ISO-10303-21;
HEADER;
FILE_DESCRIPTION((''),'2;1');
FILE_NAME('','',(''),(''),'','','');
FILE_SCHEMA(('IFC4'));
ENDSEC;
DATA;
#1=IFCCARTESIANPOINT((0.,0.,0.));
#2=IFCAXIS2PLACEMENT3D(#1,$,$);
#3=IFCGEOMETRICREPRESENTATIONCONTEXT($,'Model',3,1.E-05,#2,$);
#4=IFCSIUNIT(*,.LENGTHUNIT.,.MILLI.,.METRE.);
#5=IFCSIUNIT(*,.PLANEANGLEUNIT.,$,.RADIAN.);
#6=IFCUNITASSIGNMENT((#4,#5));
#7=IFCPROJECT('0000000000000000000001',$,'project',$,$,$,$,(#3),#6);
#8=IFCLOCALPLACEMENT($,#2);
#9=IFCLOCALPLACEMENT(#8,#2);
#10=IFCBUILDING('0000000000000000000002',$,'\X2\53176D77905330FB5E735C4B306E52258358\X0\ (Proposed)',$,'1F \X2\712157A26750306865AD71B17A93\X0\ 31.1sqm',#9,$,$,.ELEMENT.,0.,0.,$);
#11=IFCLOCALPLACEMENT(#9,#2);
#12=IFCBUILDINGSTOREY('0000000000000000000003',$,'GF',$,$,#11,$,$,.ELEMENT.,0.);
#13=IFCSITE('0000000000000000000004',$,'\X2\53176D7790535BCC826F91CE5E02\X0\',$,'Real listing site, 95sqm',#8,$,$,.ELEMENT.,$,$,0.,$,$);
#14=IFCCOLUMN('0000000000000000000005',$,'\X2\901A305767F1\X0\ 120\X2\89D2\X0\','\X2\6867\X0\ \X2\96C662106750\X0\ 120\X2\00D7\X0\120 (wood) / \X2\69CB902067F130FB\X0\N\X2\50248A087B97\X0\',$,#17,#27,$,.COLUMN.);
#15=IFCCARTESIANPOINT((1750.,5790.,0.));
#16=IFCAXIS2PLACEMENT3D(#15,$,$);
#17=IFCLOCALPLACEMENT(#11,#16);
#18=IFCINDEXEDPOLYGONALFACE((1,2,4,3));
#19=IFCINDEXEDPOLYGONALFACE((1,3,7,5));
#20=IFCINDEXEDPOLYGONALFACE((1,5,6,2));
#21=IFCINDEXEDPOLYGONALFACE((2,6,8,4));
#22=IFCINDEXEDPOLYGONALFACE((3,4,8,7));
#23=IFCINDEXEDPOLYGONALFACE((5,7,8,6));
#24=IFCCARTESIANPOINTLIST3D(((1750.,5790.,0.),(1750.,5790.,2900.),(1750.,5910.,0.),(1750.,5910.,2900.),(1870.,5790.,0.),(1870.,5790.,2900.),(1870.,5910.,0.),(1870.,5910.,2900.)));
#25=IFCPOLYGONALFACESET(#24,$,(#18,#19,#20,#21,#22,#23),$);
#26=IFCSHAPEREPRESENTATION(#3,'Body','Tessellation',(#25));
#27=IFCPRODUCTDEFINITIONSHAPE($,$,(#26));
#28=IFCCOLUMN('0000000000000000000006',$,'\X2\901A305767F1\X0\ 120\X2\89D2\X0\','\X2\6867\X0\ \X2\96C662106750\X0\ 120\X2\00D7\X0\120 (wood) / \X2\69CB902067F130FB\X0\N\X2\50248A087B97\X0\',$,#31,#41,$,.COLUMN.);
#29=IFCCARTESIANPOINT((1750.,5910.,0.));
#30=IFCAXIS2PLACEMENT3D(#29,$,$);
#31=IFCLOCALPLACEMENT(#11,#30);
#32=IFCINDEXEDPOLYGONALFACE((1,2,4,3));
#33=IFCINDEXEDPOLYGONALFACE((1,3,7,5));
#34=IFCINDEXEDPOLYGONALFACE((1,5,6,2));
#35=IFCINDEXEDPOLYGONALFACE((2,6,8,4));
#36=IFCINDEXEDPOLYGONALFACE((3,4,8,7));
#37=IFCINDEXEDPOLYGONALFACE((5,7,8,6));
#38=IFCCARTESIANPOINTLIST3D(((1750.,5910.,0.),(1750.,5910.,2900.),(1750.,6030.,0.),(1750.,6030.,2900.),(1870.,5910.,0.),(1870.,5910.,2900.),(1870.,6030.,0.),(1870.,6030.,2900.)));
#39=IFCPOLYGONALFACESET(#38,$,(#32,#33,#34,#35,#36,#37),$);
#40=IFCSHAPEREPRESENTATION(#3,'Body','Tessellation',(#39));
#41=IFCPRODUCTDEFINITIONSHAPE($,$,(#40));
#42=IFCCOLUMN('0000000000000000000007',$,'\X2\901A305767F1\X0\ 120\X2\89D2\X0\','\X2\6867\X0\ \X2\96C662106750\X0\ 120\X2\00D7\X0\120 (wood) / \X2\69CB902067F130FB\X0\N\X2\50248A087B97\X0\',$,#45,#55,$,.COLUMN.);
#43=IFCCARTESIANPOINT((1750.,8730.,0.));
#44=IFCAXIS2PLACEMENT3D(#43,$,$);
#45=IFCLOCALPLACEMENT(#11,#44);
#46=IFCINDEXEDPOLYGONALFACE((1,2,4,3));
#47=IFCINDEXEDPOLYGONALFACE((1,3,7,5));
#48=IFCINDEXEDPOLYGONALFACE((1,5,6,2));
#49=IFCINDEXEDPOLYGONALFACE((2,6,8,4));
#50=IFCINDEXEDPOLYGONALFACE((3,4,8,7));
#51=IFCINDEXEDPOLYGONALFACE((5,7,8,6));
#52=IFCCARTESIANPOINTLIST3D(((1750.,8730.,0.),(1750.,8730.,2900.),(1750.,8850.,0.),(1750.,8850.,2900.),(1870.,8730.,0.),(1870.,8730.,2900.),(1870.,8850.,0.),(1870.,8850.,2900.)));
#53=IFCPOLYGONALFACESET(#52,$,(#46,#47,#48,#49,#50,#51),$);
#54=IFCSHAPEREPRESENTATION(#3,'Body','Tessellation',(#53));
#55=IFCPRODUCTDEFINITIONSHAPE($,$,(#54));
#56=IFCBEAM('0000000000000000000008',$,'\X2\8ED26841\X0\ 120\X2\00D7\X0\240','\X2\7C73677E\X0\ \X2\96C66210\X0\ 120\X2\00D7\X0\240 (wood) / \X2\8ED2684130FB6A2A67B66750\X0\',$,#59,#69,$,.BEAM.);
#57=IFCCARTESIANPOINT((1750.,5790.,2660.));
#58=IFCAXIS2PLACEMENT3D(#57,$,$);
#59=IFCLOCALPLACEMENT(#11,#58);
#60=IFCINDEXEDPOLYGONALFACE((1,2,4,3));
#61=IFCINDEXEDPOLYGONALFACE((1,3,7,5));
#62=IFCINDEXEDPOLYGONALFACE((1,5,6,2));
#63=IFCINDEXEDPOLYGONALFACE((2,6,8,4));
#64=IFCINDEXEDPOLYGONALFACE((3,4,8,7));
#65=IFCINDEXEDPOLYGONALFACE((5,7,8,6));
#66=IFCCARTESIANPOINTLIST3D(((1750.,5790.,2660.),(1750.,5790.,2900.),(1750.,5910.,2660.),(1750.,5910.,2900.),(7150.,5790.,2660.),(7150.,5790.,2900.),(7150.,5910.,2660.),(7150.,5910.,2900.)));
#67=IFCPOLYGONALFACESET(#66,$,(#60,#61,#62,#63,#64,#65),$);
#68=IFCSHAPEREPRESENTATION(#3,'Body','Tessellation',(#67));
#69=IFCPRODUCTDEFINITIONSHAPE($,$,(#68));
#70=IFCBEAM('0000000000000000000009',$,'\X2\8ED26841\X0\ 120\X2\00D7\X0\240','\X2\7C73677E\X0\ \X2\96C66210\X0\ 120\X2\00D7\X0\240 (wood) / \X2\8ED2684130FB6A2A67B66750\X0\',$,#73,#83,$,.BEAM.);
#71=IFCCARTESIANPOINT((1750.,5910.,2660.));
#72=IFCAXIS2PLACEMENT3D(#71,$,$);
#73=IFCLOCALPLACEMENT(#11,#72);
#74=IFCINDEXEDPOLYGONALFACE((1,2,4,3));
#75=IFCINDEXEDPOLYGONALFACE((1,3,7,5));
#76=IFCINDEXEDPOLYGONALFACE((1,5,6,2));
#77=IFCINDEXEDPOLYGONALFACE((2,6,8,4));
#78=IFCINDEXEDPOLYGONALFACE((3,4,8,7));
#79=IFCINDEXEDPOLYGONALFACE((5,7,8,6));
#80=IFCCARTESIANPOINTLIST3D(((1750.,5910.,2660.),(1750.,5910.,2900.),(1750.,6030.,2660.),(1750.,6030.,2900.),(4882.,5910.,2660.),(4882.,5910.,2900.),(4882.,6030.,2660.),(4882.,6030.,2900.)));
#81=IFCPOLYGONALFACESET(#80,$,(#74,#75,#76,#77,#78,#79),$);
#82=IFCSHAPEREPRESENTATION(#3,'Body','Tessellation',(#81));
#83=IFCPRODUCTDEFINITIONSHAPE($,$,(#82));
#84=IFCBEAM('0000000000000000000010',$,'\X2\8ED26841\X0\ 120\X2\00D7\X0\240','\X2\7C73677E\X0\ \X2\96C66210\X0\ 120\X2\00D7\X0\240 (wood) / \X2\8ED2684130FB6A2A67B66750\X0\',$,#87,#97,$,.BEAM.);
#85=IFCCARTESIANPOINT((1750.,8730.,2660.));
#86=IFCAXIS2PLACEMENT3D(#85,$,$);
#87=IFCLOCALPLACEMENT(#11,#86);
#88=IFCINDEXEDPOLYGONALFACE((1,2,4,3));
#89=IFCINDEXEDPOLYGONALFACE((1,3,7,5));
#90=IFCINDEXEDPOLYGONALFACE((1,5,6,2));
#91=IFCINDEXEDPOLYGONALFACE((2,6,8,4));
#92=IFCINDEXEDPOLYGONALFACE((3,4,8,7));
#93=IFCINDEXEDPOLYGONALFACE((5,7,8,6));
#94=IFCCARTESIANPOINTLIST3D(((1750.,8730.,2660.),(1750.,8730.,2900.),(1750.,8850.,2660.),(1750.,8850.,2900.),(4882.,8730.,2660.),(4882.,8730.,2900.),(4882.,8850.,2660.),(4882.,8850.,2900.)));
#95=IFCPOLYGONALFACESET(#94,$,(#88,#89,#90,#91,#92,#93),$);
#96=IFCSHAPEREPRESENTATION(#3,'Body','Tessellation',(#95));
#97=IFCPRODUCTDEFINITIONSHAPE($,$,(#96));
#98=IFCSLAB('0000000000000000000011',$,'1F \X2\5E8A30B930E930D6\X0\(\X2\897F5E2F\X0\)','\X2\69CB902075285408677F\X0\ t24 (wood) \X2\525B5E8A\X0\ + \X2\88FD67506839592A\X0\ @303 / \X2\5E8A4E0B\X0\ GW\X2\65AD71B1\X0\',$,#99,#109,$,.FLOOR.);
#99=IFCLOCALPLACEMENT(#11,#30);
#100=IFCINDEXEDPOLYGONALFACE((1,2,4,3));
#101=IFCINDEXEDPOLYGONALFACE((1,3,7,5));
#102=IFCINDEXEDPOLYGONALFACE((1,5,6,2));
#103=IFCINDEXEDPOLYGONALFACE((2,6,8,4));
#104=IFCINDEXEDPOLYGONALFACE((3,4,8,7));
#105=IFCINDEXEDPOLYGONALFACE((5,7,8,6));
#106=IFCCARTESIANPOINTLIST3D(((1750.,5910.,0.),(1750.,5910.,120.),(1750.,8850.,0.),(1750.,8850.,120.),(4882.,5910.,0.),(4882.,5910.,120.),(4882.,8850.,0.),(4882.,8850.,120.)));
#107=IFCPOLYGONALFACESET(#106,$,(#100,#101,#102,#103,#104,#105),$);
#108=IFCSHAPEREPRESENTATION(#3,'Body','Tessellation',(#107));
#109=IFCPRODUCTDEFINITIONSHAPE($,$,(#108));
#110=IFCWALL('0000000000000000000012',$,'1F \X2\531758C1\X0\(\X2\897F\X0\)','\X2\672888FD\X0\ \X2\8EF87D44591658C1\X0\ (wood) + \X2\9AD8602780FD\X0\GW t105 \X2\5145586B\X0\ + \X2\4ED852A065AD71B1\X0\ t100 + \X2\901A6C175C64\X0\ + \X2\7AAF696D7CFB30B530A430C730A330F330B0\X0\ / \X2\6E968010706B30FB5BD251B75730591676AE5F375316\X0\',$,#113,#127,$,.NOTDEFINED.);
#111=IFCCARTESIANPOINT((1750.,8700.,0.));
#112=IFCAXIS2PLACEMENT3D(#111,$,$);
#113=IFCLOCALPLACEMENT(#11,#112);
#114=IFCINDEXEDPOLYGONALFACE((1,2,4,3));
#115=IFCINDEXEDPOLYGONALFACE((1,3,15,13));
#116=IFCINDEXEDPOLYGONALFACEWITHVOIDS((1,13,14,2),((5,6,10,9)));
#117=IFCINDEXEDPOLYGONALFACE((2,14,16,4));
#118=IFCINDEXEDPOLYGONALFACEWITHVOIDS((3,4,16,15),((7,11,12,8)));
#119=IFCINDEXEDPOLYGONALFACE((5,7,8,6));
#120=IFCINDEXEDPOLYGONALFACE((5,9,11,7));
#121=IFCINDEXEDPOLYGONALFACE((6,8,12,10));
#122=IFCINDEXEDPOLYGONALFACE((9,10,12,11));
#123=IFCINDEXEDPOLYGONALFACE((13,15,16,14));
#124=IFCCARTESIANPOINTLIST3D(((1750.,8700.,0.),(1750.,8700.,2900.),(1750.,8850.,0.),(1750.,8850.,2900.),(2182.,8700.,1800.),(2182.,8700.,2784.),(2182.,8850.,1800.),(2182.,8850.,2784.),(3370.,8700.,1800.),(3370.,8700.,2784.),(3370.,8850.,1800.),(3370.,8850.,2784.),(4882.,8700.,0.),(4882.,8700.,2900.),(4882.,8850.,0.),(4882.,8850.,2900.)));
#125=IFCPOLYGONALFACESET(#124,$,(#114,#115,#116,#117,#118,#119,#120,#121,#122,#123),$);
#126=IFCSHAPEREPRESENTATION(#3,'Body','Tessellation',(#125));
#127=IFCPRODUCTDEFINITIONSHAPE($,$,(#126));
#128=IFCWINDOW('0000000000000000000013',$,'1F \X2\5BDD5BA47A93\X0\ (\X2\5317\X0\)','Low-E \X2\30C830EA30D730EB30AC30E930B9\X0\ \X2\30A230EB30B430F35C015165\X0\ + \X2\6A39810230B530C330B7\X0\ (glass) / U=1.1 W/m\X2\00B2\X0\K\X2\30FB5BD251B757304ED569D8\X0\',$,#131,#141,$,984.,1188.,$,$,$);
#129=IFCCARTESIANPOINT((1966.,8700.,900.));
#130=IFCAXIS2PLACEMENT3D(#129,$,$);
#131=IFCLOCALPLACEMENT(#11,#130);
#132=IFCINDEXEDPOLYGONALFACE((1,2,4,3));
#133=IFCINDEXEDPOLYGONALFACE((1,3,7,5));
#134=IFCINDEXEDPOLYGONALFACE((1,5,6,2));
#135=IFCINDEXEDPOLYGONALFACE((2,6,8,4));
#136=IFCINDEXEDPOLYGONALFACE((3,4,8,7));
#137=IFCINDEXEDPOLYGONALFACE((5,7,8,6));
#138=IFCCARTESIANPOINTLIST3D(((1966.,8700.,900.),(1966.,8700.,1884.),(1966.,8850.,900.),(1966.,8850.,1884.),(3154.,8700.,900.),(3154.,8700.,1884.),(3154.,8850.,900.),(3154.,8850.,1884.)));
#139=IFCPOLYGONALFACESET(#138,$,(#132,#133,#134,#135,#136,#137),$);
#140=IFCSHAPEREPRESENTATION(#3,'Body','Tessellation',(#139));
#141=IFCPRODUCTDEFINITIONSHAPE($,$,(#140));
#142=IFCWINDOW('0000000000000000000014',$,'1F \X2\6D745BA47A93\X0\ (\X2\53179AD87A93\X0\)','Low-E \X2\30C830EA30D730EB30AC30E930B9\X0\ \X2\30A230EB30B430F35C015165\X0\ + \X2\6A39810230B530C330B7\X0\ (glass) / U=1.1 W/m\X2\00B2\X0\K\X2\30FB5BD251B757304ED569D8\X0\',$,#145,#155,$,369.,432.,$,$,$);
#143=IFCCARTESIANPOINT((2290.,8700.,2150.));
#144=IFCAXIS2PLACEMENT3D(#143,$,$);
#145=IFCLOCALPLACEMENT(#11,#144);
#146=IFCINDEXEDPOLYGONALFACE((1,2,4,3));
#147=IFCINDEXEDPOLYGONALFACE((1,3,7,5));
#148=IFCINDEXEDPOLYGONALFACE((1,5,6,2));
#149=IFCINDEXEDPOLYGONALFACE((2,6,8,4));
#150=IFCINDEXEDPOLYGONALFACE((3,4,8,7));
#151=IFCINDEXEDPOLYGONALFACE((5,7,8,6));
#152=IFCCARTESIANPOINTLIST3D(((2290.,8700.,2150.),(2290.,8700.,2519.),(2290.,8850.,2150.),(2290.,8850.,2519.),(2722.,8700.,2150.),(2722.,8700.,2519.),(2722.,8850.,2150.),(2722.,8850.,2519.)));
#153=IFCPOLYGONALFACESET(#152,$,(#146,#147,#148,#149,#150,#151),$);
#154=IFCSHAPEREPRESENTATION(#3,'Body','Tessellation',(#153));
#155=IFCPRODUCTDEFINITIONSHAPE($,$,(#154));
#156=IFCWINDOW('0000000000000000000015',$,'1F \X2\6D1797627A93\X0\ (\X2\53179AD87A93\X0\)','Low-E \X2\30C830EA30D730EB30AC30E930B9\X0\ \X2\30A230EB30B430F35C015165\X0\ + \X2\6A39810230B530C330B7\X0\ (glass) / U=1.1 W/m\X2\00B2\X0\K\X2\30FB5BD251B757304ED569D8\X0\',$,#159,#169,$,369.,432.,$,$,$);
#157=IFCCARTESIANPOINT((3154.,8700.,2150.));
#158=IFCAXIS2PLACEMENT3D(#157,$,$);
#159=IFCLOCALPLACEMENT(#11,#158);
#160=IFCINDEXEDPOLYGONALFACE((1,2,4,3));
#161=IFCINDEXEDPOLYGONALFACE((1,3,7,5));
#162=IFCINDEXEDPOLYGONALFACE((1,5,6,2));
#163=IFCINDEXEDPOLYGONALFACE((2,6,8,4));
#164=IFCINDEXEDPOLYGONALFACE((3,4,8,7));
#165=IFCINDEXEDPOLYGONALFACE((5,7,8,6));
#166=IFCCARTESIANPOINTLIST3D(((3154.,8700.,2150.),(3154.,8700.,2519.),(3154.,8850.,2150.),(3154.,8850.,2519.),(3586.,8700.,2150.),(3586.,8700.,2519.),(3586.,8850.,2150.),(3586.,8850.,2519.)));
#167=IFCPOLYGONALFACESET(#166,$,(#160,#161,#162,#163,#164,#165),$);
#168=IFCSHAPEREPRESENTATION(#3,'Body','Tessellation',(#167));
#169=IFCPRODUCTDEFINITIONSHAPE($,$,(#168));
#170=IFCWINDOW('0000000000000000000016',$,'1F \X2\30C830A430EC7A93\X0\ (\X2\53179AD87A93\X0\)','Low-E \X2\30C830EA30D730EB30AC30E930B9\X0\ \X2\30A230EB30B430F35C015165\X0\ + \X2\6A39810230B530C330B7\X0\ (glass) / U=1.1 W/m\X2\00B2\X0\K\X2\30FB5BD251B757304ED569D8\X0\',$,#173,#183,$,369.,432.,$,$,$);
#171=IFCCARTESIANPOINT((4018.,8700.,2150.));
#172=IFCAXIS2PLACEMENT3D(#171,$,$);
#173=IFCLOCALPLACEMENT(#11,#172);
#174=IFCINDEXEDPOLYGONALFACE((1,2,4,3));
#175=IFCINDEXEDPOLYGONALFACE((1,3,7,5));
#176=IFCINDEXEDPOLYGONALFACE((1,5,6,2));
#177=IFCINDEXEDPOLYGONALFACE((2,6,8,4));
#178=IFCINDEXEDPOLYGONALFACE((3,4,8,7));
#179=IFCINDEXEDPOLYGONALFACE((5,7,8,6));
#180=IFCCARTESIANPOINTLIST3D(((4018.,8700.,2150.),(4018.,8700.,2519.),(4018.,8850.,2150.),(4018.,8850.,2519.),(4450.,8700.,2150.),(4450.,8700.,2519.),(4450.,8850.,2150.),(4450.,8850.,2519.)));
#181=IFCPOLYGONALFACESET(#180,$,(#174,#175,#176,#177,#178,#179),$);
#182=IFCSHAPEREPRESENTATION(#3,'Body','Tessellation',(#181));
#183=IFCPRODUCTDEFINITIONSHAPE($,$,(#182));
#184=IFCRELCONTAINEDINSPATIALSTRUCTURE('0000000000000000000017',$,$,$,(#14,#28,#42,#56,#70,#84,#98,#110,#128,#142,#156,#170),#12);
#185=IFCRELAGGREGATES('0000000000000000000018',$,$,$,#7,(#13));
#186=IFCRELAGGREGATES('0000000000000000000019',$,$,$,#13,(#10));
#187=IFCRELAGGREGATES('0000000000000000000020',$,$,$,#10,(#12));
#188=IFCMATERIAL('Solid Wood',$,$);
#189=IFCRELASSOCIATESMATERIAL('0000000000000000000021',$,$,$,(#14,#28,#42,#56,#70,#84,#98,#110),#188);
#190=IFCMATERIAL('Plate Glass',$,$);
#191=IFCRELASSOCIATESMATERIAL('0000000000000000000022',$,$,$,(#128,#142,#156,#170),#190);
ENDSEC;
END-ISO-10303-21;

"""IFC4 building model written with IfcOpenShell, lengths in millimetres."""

from ifc_helpers import new_model, si_unit, frame, frame_2d, origin, place, context, project, spatial, rectangle, extrude, material, element, fill, save


model = new_model("IFC4")

# Units and contexts
model_context = context("Model", 3, precision=1e-05, world=origin())
ifc_project = project(units=[si_unit("LENGTHUNIT", "METRE", prefix="MILLI"), si_unit("PLANEANGLEUNIT", "RADIAN")], contexts=[model_context])

# Site, building, storey
site_placement = place(None, origin())
site = spatial("IfcSite", under=ifc_project, at=site_placement, Name="北海道富良野市", ObjectType="Real listing site, 95sqm", CompositionType="ELEMENT", RefElevation=0.0)
building_placement = place(site_placement, origin())
building = spatial("IfcBuilding", under=site, at=building_placement, Name="北海道・平屋の別荘 (Proposed)", ObjectType="1F 無垢材と断熱窓 31.1sqm", CompositionType="ELEMENT", ElevationOfRefHeight=0.0, ElevationOfTerrain=0.0)
storey_placement = place(building_placement, origin())
storey = spatial("IfcBuildingStorey", under=building, at=storey_placement, Name="GF", CompositionType="ELEMENT", Elevation=0.0)

# Columns
ifc_material_1 = material(Name="Solid Wood")
column_1_placement = place(storey_placement, frame((1750.0, 5790.0, 0.0)))
element("IfcColumn", 1, at=column_1_placement, inside=storey, material=ifc_material_1, Name="通し柱 120角", Description="桧 集成材 120×120 (wood) / 構造柱・N値計算", PredefinedType="COLUMN", context=model_context, shape_type="SweptSolid", body=[
    extrude(rectangle(XDim=120.0, YDim=120.0, at=frame_2d((60.0, 60.0))), frame((1750.0, 5790.0, 0.0)), (0.0, 0.0, 1.0), 2900.0),
])
column_2_placement = place(storey_placement, frame((1750.0, 5910.0, 0.0)))
element("IfcColumn", 2, at=column_2_placement, inside=storey, material=ifc_material_1, Name="通し柱 120角", Description="桧 集成材 120×120 (wood) / 構造柱・N値計算", PredefinedType="COLUMN", context=model_context, shape_type="SweptSolid", body=[
    extrude(rectangle(XDim=120.0, YDim=120.0, at=frame_2d((60.0, 60.0))), frame((1750.0, 5910.0, 0.0)), (0.0, 0.0, 1.0), 2900.0),
])
column_3_placement = place(storey_placement, frame((1750.0, 8730.0, 0.0)))
element("IfcColumn", 3, at=column_3_placement, inside=storey, material=ifc_material_1, Name="通し柱 120角", Description="桧 集成材 120×120 (wood) / 構造柱・N値計算", PredefinedType="COLUMN", context=model_context, shape_type="SweptSolid", body=[
    extrude(rectangle(XDim=120.0, YDim=120.0, at=frame_2d((60.0, 60.0))), frame((1750.0, 8730.0, 0.0)), (0.0, 0.0, 1.0), 2900.0),
])

# Beams
beam_1_placement = place(storey_placement, frame((1750.0, 5790.0, 2660.0)))
element("IfcBeam", 4, at=beam_1_placement, inside=storey, material=ifc_material_1, Name="軒桁 120×240", Description="米松 集成 120×240 (wood) / 軒桁・横架材", PredefinedType="BEAM", context=model_context, shape_type="SweptSolid", body=[
    extrude(rectangle(XDim=5400.0, YDim=120.0, at=frame_2d((2700.0, 60.0))), frame((1750.0, 5790.0, 2660.0)), (0.0, 0.0, 1.0), 240.0),
])
beam_2_placement = place(storey_placement, frame((1750.0, 5910.0, 2660.0)))
element("IfcBeam", 5, at=beam_2_placement, inside=storey, material=ifc_material_1, Name="軒桁 120×240", Description="米松 集成 120×240 (wood) / 軒桁・横架材", PredefinedType="BEAM", context=model_context, shape_type="SweptSolid", body=[
    extrude(rectangle(XDim=3132.0, YDim=120.0, at=frame_2d((1566.0, 60.0))), frame((1750.0, 5910.0, 2660.0)), (0.0, 0.0, 1.0), 240.0),
])
beam_3_placement = place(storey_placement, frame((1750.0, 8730.0, 2660.0)))
element("IfcBeam", 6, at=beam_3_placement, inside=storey, material=ifc_material_1, Name="軒桁 120×240", Description="米松 集成 120×240 (wood) / 軒桁・横架材", PredefinedType="BEAM", context=model_context, shape_type="SweptSolid", body=[
    extrude(rectangle(XDim=3132.0, YDim=120.0, at=frame_2d((1566.0, 60.0))), frame((1750.0, 8730.0, 2660.0)), (0.0, 0.0, 1.0), 240.0),
])

# Slab
slab_placement = place(storey_placement, frame((1750.0, 5910.0, 0.0)))
element("IfcSlab", 7, at=slab_placement, inside=storey, material=ifc_material_1, Name="1F 床スラブ(西帯)", Description="構造用合板 t24 (wood) 剛床 + 製材根太 @303 / 床下 GW断熱", PredefinedType="FLOOR", context=model_context, shape_type="SweptSolid", body=[
    extrude(rectangle(XDim=3132.0, YDim=2940.0, at=frame_2d((1566.0, 1470.0))), frame((1750.0, 5910.0, 0.0)), (0.0, 0.0, 1.0), 120.0),
])

# Wall, openings, windows
wall_1_placement = place(storey_placement, frame((1750.0, 8700.0, 0.0)))
wall_1 = element("IfcWall", 8, at=wall_1_placement, inside=storey, material=ifc_material_1, Name="1F 北壁(西)", Description="木製 軸組外壁 (wood) + 高性能GW t105 充填 + 付加断熱 t100 + 通気層 + 窯業系サイディング / 準耐火・寒冷地外皮強化", PredefinedType="NOTDEFINED", context=model_context, shape_type="SweptSolid", body=[
    extrude(rectangle(XDim=3132.0, YDim=150.0, at=frame_2d((1566.0, 75.0))), frame((1750.0, 8700.0, 0.0)), (0.0, 0.0, 1.0), 2900.0),
])
opening_1_placement = place(storey_placement, frame((1966.0, 8700.0, 900.0)))
opening_1 = element("IfcOpeningElement", 9, at=opening_1_placement, cuts=wall_1, PredefinedType="NOTDEFINED", context=model_context, shape_type="SweptSolid", body=[
    extrude(rectangle(XDim=1188.0, YDim=150.0, at=frame_2d((594.0, 75.0))), frame((1966.0, 8700.0, 900.0)), (0.0, 0.0, 1.0), 984.0),
])
opening_2_placement = place(storey_placement, frame((2290.0, 8700.0, 2150.0)))
opening_2 = element("IfcOpeningElement", 10, at=opening_2_placement, cuts=wall_1, PredefinedType="NOTDEFINED", context=model_context, shape_type="SweptSolid", body=[
    extrude(rectangle(XDim=432.0, YDim=150.0, at=frame_2d((216.0, 75.0))), frame((2290.0, 8700.0, 2150.0)), (0.0, 0.0, 1.0), 369.0),
])
opening_3_placement = place(storey_placement, frame((3154.0, 8700.0, 2150.0)))
opening_3 = element("IfcOpeningElement", 11, at=opening_3_placement, cuts=wall_1, PredefinedType="NOTDEFINED", context=model_context, shape_type="SweptSolid", body=[
    extrude(rectangle(XDim=432.0, YDim=150.0, at=frame_2d((216.0, 75.0))), frame((3154.0, 8700.0, 2150.0)), (0.0, 0.0, 1.0), 369.0),
])
opening_4_placement = place(storey_placement, frame((4018.0, 8700.0, 2150.0)))
opening_4 = element("IfcOpeningElement", 12, at=opening_4_placement, cuts=wall_1, PredefinedType="NOTDEFINED", context=model_context, shape_type="SweptSolid", body=[
    extrude(rectangle(XDim=432.0, YDim=150.0, at=frame_2d((216.0, 75.0))), frame((4018.0, 8700.0, 2150.0)), (0.0, 0.0, 1.0), 369.0),
])
ifc_material_2 = material(Name="Plate Glass")
window_1_placement = place(storey_placement, frame((1966.0, 8700.0, 900.0)))
window_1 = element("IfcWindow", 13, at=window_1_placement, inside=storey, material=ifc_material_2, Name="1F 寝室窓 (北)", Description="Low-E トリプルガラス アルゴン封入 + 樹脂サッシ (glass) / U=1.1 W/m²K・寒冷地仕様", OverallHeight=984.0, OverallWidth=1188.0, context=model_context, shape_type="SweptSolid", body=[
    extrude(rectangle(XDim=1188.0, YDim=150.0, at=frame_2d((594.0, 75.0))), frame((1966.0, 8700.0, 900.0)), (0.0, 0.0, 1.0), 984.0),
])
fill(opening_1, window_1)
window_2_placement = place(storey_placement, frame((2290.0, 8700.0, 2150.0)))
window_2 = element("IfcWindow", 14, at=window_2_placement, inside=storey, material=ifc_material_2, Name="1F 浴室窓 (北高窓)", Description="Low-E トリプルガラス アルゴン封入 + 樹脂サッシ (glass) / U=1.1 W/m²K・寒冷地仕様", OverallHeight=369.0, OverallWidth=432.0, context=model_context, shape_type="SweptSolid", body=[
    extrude(rectangle(XDim=432.0, YDim=150.0, at=frame_2d((216.0, 75.0))), frame((2290.0, 8700.0, 2150.0)), (0.0, 0.0, 1.0), 369.0),
])
fill(opening_2, window_2)
window_3_placement = place(storey_placement, frame((3154.0, 8700.0, 2150.0)))
window_3 = element("IfcWindow", 15, at=window_3_placement, inside=storey, material=ifc_material_2, Name="1F 洗面窓 (北高窓)", Description="Low-E トリプルガラス アルゴン封入 + 樹脂サッシ (glass) / U=1.1 W/m²K・寒冷地仕様", OverallHeight=369.0, OverallWidth=432.0, context=model_context, shape_type="SweptSolid", body=[
    extrude(rectangle(XDim=432.0, YDim=150.0, at=frame_2d((216.0, 75.0))), frame((3154.0, 8700.0, 2150.0)), (0.0, 0.0, 1.0), 369.0),
])
fill(opening_3, window_3)
window_4_placement = place(storey_placement, frame((4018.0, 8700.0, 2150.0)))
window_4 = element("IfcWindow", 16, at=window_4_placement, inside=storey, material=ifc_material_2, Name="1F トイレ窓 (北高窓)", Description="Low-E トリプルガラス アルゴン封入 + 樹脂サッシ (glass) / U=1.1 W/m²K・寒冷地仕様", OverallHeight=369.0, OverallWidth=432.0, context=model_context, shape_type="SweptSolid", body=[
    extrude(rectangle(XDim=432.0, YDim=150.0, at=frame_2d((216.0, 75.0))), frame((4018.0, 8700.0, 2150.0)), (0.0, 0.0, 1.0), 369.0),
])
fill(opening_4, window_4)

save(model, "model.ifc")
